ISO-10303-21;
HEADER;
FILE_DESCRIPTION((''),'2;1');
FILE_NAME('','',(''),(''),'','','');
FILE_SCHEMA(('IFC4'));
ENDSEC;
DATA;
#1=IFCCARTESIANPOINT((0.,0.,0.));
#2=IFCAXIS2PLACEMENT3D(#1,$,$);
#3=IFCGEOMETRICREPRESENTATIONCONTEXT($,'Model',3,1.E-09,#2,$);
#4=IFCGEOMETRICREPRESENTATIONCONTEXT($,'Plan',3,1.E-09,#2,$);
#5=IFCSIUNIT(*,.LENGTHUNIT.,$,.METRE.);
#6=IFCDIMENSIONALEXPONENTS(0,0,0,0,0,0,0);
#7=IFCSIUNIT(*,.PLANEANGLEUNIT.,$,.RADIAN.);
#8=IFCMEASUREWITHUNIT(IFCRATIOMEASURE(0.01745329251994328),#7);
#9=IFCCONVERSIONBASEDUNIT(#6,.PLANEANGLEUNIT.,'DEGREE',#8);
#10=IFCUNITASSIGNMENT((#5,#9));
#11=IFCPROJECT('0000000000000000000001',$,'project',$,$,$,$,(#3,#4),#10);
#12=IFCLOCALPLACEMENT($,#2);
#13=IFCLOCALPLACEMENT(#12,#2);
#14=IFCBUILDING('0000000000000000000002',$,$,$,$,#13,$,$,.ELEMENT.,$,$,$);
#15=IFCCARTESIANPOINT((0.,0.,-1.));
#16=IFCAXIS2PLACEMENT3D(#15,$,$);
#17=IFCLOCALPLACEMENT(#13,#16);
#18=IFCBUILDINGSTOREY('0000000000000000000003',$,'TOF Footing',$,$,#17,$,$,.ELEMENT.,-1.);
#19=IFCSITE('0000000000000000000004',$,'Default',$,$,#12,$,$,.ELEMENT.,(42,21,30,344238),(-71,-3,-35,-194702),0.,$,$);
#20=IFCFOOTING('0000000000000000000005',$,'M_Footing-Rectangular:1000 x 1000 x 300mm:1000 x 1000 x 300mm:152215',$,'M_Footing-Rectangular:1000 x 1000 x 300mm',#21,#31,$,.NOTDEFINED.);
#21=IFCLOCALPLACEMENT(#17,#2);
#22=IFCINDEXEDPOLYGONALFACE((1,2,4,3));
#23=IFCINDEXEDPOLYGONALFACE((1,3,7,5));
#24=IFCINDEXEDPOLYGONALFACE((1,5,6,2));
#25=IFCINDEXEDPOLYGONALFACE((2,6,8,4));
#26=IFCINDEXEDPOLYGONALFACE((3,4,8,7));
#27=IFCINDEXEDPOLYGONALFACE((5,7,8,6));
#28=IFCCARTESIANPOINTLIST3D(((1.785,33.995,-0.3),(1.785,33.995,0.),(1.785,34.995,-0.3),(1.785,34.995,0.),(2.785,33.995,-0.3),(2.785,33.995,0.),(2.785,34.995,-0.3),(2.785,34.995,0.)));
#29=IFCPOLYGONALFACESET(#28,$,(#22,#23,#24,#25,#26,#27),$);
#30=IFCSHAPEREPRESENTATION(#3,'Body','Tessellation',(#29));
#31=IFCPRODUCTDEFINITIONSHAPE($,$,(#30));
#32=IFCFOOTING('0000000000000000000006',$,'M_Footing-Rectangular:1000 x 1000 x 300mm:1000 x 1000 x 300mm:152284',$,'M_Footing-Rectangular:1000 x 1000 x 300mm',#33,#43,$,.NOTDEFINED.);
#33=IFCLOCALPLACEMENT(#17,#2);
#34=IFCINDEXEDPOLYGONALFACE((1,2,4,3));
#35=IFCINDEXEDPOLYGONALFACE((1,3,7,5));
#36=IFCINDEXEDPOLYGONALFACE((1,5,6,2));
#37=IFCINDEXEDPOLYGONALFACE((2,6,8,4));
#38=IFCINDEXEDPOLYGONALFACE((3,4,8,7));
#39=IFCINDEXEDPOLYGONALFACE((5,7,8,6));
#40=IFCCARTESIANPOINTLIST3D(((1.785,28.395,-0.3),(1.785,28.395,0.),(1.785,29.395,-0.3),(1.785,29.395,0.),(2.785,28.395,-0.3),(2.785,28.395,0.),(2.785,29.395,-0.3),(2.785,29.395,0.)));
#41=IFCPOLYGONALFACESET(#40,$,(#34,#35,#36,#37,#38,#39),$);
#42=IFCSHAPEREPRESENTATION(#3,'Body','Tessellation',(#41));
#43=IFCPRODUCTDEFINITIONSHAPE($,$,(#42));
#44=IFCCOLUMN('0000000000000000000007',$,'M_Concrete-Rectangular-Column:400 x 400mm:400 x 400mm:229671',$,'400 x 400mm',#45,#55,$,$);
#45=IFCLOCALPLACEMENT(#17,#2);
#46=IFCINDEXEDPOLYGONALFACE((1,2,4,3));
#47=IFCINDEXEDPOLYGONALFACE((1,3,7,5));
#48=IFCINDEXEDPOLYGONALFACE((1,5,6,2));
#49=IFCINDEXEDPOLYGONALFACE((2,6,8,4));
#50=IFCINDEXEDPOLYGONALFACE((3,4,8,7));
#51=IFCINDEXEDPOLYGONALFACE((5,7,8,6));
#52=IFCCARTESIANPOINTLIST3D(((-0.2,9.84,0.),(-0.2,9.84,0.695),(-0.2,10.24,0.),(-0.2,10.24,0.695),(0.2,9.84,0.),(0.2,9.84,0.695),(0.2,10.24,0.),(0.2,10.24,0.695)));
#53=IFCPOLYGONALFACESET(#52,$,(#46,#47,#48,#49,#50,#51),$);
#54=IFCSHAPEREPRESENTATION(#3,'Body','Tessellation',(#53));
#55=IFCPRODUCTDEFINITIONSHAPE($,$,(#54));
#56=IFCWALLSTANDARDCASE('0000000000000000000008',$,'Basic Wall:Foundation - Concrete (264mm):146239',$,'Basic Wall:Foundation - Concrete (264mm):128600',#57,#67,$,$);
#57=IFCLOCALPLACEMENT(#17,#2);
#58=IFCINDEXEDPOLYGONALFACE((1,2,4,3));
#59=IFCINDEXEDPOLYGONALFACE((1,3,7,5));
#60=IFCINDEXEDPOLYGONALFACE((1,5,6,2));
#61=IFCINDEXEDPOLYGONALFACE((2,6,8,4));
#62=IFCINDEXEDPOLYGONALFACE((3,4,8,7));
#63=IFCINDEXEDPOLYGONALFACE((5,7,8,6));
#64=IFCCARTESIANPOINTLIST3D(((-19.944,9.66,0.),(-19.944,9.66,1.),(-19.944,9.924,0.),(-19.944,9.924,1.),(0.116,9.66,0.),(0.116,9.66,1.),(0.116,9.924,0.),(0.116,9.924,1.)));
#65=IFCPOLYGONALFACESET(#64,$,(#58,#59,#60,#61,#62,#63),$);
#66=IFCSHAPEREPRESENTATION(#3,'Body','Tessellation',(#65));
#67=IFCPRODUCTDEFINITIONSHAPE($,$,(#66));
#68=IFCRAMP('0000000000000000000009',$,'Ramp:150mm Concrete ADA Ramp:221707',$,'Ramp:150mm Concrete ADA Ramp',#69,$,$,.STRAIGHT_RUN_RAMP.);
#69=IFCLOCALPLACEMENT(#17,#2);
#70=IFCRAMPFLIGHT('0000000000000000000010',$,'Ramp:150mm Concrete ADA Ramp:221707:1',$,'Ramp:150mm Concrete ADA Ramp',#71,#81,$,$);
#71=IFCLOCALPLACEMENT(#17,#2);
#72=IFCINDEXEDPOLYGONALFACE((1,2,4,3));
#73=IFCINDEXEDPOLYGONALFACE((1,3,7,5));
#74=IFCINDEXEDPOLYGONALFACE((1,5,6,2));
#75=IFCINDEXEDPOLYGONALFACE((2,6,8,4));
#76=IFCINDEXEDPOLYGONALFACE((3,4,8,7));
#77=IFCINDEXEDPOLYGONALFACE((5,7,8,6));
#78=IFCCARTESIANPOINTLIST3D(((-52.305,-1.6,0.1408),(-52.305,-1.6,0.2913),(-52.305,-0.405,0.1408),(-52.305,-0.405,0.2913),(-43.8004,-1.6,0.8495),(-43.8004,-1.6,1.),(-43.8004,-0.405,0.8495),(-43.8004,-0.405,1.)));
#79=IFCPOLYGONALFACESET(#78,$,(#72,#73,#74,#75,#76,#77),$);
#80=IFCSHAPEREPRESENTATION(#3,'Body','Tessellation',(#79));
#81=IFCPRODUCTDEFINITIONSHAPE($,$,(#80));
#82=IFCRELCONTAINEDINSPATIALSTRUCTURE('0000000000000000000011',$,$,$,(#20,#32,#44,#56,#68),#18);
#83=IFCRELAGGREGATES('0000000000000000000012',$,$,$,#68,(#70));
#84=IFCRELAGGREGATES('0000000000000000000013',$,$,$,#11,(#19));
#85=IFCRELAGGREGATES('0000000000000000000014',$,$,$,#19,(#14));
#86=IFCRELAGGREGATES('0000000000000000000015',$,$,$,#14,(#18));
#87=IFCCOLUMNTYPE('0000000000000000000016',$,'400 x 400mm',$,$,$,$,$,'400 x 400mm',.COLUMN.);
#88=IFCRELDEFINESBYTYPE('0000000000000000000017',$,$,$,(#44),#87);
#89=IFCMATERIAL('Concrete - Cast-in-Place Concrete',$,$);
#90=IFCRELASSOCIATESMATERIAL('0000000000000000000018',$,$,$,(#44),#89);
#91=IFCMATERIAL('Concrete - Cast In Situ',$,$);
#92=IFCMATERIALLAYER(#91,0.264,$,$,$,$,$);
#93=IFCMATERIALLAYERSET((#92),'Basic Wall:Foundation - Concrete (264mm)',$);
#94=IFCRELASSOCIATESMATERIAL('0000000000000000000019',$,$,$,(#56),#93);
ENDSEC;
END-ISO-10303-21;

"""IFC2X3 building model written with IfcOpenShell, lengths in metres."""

from ifc_helpers import new_model, entity, si_unit, converted_unit, frame, frame_2d, origin, origin_2d_with_axis, place, context, project, spatial, polyline, rectangle, outline, extrude, source, transform, mapped, material, layer, layer_set, layer_usage, type_object, type_shapes, element, aggregate, save


model = new_model("IFC2X3")

# Units and contexts
model_context = context("Model", 3, precision=1e-09, world=origin())
plan_context = context("Plan", 3, precision=1e-09, world=origin())
ifc_project = project(units=[si_unit("LENGTHUNIT", "METRE"), converted_unit("PLANEANGLEUNIT", "DEGREE", entity("IfcRatioMeasure", 0.01745329251994328), si_unit("PLANEANGLEUNIT", "RADIAN"), dimensions=[0, 0, 0, 0, 0, 0, 0])], contexts=[model_context, plan_context])

# Site, building, storey
site_placement = place(None, origin())
site = spatial("IfcSite", under=ifc_project, at=site_placement, Name="Default", CompositionType="ELEMENT", RefLatitude=(42, 21, 30, 344238), RefLongitude=(-71, -3, -35, -194702), RefElevation=0.0)
building_placement = place(site_placement, origin())
building = spatial("IfcBuilding", under=site, at=building_placement, CompositionType="ELEMENT")
storey_placement = place(building_placement, frame((0.0, 0.0, -1.0)))
storey = spatial("IfcBuildingStorey", under=building, at=storey_placement, Name="TOF Footing", CompositionType="ELEMENT", Elevation=-1.0)

# Footings
footing_1_placement = place(storey_placement, origin())
element("IfcFooting", 1, at=footing_1_placement, inside=storey, Name="M_Footing-Rectangular:1000 x 1000 x 300mm:1000 x 1000 x 300mm:152215", ObjectType="M_Footing-Rectangular:1000 x 1000 x 300mm", PredefinedType="NOTDEFINED", context=model_context, shape_type="SweptSolid", body=[
    extrude(rectangle(XDim=1.0, YDim=1.0, at=origin_2d_with_axis()), frame((2.285, 34.495, -0.3), z_axis=(0.0, 0.0, 1.0), x_axis=(-1.0, 0.0, 0.0)), (0.0, 0.0, 1.0), 0.3),
])
footing_2_placement = place(storey_placement, origin())
element("IfcFooting", 2, at=footing_2_placement, inside=storey, Name="M_Footing-Rectangular:1000 x 1000 x 300mm:1000 x 1000 x 300mm:152284", ObjectType="M_Footing-Rectangular:1000 x 1000 x 300mm", PredefinedType="NOTDEFINED", context=model_context, shape_type="SweptSolid", body=[
    extrude(rectangle(XDim=1.0, YDim=1.0, at=origin_2d_with_axis()), frame((2.285, 28.895, -0.3), z_axis=(0.0, 0.0, 1.0), x_axis=(-1.0, 0.0, 0.0)), (0.0, 0.0, 1.0), 0.3),
])

# Column
ifc_material_1 = material(Name="Concrete - Cast-in-Place Concrete")
column_type_1 = type_object("IfcColumnType", Name="400 x 400mm", ElementType="400 x 400mm", PredefinedType="COLUMN")
shared_shape_1 = source(origin(), model_context, "Body", "SweptSolid", [
    extrude(rectangle(XDim=0.4, YDim=0.4, at=frame_2d((0.0, 0.0), x_axis=(0.0, -1.0))), origin(), (0.0, 0.0, 1.0), 0.695),
])
type_shapes(column_type_1, [shared_shape_1])
column_1_placement = place(storey_placement, frame((0.0, 10.04, 0.0), z_axis=(0.0, 0.0, 1.0), x_axis=(0.0, 1.0, 0.0)))
element("IfcColumn", 3, at=column_1_placement, inside=storey, type_object=column_type_1, material=ifc_material_1, Name="M_Concrete-Rectangular-Column:400 x 400mm:400 x 400mm:229671", ObjectType="400 x 400mm", context=model_context, shape_type="MappedRepresentation", body=[
    mapped(shared_shape_1, transform((0.0, 0.0, 0.0), scale=1.0)),
])

# Wall
ifc_material_2 = material(Name="Concrete - Cast In Situ")
ifc_layer = layer(ifc_material_2, 0.264)
ifc_layer_set = layer_set([ifc_layer], Name="Basic Wall:Foundation - Concrete (264mm)")
ifc_layer_usage = layer_usage(ifc_layer_set, "AXIS2", "NEGATIVE", 0.132)
wall_placement = place(storey_placement, frame((0.116, 9.792, 0.0), z_axis=(0.0, 0.0, 1.0), x_axis=(-1.0, 0.0, 0.0)))
element("IfcWallStandardCase", 4, at=wall_placement, inside=storey, material=ifc_layer_usage, Name="Basic Wall:Foundation - Concrete (264mm):146239", ObjectType="Basic Wall:Foundation - Concrete (264mm):128600", context=model_context, shape_type="SweptSolid", body=[
    extrude(rectangle(XDim=20.06, YDim=0.264, at=frame_2d((10.03, 0.0), x_axis=(-1.0, 0.0))), origin(), (0.0, 0.0, 1.0), 1.0),
])

# Ramp, ramp flight
ramp_placement = place(storey_placement, origin())
ramp = element("IfcRamp", 5, at=ramp_placement, inside=storey, Name="Ramp:150mm Concrete ADA Ramp:221707", ObjectType="Ramp:150mm Concrete ADA Ramp", ShapeType="STRAIGHT_RUN_RAMP")
ramp_flight_placement = place(storey_placement, origin())
ramp_flight = element("IfcRampFlight", 6, at=ramp_flight_placement, Name="Ramp:150mm Concrete ADA Ramp:221707:1", ObjectType="Ramp:150mm Concrete ADA Ramp", context=model_context, shape_type="SweptSolid", body=[
    extrude(outline(polyline([(-0.4296, -4.2523), (-0.2791, -4.2523), (0.4296, 4.2523), (0.2791, 4.2523), (-0.4296, -4.2523)])), frame((-48.0527, -1.6, 0.5704), z_axis=(0.0, 1.0, 0.0), x_axis=(0.0, 0.0, -1.0)), (0.0, 0.0, 1.0), 1.195),
])
aggregate(ramp, [ramp_flight])

save(model, "model.ifc")
